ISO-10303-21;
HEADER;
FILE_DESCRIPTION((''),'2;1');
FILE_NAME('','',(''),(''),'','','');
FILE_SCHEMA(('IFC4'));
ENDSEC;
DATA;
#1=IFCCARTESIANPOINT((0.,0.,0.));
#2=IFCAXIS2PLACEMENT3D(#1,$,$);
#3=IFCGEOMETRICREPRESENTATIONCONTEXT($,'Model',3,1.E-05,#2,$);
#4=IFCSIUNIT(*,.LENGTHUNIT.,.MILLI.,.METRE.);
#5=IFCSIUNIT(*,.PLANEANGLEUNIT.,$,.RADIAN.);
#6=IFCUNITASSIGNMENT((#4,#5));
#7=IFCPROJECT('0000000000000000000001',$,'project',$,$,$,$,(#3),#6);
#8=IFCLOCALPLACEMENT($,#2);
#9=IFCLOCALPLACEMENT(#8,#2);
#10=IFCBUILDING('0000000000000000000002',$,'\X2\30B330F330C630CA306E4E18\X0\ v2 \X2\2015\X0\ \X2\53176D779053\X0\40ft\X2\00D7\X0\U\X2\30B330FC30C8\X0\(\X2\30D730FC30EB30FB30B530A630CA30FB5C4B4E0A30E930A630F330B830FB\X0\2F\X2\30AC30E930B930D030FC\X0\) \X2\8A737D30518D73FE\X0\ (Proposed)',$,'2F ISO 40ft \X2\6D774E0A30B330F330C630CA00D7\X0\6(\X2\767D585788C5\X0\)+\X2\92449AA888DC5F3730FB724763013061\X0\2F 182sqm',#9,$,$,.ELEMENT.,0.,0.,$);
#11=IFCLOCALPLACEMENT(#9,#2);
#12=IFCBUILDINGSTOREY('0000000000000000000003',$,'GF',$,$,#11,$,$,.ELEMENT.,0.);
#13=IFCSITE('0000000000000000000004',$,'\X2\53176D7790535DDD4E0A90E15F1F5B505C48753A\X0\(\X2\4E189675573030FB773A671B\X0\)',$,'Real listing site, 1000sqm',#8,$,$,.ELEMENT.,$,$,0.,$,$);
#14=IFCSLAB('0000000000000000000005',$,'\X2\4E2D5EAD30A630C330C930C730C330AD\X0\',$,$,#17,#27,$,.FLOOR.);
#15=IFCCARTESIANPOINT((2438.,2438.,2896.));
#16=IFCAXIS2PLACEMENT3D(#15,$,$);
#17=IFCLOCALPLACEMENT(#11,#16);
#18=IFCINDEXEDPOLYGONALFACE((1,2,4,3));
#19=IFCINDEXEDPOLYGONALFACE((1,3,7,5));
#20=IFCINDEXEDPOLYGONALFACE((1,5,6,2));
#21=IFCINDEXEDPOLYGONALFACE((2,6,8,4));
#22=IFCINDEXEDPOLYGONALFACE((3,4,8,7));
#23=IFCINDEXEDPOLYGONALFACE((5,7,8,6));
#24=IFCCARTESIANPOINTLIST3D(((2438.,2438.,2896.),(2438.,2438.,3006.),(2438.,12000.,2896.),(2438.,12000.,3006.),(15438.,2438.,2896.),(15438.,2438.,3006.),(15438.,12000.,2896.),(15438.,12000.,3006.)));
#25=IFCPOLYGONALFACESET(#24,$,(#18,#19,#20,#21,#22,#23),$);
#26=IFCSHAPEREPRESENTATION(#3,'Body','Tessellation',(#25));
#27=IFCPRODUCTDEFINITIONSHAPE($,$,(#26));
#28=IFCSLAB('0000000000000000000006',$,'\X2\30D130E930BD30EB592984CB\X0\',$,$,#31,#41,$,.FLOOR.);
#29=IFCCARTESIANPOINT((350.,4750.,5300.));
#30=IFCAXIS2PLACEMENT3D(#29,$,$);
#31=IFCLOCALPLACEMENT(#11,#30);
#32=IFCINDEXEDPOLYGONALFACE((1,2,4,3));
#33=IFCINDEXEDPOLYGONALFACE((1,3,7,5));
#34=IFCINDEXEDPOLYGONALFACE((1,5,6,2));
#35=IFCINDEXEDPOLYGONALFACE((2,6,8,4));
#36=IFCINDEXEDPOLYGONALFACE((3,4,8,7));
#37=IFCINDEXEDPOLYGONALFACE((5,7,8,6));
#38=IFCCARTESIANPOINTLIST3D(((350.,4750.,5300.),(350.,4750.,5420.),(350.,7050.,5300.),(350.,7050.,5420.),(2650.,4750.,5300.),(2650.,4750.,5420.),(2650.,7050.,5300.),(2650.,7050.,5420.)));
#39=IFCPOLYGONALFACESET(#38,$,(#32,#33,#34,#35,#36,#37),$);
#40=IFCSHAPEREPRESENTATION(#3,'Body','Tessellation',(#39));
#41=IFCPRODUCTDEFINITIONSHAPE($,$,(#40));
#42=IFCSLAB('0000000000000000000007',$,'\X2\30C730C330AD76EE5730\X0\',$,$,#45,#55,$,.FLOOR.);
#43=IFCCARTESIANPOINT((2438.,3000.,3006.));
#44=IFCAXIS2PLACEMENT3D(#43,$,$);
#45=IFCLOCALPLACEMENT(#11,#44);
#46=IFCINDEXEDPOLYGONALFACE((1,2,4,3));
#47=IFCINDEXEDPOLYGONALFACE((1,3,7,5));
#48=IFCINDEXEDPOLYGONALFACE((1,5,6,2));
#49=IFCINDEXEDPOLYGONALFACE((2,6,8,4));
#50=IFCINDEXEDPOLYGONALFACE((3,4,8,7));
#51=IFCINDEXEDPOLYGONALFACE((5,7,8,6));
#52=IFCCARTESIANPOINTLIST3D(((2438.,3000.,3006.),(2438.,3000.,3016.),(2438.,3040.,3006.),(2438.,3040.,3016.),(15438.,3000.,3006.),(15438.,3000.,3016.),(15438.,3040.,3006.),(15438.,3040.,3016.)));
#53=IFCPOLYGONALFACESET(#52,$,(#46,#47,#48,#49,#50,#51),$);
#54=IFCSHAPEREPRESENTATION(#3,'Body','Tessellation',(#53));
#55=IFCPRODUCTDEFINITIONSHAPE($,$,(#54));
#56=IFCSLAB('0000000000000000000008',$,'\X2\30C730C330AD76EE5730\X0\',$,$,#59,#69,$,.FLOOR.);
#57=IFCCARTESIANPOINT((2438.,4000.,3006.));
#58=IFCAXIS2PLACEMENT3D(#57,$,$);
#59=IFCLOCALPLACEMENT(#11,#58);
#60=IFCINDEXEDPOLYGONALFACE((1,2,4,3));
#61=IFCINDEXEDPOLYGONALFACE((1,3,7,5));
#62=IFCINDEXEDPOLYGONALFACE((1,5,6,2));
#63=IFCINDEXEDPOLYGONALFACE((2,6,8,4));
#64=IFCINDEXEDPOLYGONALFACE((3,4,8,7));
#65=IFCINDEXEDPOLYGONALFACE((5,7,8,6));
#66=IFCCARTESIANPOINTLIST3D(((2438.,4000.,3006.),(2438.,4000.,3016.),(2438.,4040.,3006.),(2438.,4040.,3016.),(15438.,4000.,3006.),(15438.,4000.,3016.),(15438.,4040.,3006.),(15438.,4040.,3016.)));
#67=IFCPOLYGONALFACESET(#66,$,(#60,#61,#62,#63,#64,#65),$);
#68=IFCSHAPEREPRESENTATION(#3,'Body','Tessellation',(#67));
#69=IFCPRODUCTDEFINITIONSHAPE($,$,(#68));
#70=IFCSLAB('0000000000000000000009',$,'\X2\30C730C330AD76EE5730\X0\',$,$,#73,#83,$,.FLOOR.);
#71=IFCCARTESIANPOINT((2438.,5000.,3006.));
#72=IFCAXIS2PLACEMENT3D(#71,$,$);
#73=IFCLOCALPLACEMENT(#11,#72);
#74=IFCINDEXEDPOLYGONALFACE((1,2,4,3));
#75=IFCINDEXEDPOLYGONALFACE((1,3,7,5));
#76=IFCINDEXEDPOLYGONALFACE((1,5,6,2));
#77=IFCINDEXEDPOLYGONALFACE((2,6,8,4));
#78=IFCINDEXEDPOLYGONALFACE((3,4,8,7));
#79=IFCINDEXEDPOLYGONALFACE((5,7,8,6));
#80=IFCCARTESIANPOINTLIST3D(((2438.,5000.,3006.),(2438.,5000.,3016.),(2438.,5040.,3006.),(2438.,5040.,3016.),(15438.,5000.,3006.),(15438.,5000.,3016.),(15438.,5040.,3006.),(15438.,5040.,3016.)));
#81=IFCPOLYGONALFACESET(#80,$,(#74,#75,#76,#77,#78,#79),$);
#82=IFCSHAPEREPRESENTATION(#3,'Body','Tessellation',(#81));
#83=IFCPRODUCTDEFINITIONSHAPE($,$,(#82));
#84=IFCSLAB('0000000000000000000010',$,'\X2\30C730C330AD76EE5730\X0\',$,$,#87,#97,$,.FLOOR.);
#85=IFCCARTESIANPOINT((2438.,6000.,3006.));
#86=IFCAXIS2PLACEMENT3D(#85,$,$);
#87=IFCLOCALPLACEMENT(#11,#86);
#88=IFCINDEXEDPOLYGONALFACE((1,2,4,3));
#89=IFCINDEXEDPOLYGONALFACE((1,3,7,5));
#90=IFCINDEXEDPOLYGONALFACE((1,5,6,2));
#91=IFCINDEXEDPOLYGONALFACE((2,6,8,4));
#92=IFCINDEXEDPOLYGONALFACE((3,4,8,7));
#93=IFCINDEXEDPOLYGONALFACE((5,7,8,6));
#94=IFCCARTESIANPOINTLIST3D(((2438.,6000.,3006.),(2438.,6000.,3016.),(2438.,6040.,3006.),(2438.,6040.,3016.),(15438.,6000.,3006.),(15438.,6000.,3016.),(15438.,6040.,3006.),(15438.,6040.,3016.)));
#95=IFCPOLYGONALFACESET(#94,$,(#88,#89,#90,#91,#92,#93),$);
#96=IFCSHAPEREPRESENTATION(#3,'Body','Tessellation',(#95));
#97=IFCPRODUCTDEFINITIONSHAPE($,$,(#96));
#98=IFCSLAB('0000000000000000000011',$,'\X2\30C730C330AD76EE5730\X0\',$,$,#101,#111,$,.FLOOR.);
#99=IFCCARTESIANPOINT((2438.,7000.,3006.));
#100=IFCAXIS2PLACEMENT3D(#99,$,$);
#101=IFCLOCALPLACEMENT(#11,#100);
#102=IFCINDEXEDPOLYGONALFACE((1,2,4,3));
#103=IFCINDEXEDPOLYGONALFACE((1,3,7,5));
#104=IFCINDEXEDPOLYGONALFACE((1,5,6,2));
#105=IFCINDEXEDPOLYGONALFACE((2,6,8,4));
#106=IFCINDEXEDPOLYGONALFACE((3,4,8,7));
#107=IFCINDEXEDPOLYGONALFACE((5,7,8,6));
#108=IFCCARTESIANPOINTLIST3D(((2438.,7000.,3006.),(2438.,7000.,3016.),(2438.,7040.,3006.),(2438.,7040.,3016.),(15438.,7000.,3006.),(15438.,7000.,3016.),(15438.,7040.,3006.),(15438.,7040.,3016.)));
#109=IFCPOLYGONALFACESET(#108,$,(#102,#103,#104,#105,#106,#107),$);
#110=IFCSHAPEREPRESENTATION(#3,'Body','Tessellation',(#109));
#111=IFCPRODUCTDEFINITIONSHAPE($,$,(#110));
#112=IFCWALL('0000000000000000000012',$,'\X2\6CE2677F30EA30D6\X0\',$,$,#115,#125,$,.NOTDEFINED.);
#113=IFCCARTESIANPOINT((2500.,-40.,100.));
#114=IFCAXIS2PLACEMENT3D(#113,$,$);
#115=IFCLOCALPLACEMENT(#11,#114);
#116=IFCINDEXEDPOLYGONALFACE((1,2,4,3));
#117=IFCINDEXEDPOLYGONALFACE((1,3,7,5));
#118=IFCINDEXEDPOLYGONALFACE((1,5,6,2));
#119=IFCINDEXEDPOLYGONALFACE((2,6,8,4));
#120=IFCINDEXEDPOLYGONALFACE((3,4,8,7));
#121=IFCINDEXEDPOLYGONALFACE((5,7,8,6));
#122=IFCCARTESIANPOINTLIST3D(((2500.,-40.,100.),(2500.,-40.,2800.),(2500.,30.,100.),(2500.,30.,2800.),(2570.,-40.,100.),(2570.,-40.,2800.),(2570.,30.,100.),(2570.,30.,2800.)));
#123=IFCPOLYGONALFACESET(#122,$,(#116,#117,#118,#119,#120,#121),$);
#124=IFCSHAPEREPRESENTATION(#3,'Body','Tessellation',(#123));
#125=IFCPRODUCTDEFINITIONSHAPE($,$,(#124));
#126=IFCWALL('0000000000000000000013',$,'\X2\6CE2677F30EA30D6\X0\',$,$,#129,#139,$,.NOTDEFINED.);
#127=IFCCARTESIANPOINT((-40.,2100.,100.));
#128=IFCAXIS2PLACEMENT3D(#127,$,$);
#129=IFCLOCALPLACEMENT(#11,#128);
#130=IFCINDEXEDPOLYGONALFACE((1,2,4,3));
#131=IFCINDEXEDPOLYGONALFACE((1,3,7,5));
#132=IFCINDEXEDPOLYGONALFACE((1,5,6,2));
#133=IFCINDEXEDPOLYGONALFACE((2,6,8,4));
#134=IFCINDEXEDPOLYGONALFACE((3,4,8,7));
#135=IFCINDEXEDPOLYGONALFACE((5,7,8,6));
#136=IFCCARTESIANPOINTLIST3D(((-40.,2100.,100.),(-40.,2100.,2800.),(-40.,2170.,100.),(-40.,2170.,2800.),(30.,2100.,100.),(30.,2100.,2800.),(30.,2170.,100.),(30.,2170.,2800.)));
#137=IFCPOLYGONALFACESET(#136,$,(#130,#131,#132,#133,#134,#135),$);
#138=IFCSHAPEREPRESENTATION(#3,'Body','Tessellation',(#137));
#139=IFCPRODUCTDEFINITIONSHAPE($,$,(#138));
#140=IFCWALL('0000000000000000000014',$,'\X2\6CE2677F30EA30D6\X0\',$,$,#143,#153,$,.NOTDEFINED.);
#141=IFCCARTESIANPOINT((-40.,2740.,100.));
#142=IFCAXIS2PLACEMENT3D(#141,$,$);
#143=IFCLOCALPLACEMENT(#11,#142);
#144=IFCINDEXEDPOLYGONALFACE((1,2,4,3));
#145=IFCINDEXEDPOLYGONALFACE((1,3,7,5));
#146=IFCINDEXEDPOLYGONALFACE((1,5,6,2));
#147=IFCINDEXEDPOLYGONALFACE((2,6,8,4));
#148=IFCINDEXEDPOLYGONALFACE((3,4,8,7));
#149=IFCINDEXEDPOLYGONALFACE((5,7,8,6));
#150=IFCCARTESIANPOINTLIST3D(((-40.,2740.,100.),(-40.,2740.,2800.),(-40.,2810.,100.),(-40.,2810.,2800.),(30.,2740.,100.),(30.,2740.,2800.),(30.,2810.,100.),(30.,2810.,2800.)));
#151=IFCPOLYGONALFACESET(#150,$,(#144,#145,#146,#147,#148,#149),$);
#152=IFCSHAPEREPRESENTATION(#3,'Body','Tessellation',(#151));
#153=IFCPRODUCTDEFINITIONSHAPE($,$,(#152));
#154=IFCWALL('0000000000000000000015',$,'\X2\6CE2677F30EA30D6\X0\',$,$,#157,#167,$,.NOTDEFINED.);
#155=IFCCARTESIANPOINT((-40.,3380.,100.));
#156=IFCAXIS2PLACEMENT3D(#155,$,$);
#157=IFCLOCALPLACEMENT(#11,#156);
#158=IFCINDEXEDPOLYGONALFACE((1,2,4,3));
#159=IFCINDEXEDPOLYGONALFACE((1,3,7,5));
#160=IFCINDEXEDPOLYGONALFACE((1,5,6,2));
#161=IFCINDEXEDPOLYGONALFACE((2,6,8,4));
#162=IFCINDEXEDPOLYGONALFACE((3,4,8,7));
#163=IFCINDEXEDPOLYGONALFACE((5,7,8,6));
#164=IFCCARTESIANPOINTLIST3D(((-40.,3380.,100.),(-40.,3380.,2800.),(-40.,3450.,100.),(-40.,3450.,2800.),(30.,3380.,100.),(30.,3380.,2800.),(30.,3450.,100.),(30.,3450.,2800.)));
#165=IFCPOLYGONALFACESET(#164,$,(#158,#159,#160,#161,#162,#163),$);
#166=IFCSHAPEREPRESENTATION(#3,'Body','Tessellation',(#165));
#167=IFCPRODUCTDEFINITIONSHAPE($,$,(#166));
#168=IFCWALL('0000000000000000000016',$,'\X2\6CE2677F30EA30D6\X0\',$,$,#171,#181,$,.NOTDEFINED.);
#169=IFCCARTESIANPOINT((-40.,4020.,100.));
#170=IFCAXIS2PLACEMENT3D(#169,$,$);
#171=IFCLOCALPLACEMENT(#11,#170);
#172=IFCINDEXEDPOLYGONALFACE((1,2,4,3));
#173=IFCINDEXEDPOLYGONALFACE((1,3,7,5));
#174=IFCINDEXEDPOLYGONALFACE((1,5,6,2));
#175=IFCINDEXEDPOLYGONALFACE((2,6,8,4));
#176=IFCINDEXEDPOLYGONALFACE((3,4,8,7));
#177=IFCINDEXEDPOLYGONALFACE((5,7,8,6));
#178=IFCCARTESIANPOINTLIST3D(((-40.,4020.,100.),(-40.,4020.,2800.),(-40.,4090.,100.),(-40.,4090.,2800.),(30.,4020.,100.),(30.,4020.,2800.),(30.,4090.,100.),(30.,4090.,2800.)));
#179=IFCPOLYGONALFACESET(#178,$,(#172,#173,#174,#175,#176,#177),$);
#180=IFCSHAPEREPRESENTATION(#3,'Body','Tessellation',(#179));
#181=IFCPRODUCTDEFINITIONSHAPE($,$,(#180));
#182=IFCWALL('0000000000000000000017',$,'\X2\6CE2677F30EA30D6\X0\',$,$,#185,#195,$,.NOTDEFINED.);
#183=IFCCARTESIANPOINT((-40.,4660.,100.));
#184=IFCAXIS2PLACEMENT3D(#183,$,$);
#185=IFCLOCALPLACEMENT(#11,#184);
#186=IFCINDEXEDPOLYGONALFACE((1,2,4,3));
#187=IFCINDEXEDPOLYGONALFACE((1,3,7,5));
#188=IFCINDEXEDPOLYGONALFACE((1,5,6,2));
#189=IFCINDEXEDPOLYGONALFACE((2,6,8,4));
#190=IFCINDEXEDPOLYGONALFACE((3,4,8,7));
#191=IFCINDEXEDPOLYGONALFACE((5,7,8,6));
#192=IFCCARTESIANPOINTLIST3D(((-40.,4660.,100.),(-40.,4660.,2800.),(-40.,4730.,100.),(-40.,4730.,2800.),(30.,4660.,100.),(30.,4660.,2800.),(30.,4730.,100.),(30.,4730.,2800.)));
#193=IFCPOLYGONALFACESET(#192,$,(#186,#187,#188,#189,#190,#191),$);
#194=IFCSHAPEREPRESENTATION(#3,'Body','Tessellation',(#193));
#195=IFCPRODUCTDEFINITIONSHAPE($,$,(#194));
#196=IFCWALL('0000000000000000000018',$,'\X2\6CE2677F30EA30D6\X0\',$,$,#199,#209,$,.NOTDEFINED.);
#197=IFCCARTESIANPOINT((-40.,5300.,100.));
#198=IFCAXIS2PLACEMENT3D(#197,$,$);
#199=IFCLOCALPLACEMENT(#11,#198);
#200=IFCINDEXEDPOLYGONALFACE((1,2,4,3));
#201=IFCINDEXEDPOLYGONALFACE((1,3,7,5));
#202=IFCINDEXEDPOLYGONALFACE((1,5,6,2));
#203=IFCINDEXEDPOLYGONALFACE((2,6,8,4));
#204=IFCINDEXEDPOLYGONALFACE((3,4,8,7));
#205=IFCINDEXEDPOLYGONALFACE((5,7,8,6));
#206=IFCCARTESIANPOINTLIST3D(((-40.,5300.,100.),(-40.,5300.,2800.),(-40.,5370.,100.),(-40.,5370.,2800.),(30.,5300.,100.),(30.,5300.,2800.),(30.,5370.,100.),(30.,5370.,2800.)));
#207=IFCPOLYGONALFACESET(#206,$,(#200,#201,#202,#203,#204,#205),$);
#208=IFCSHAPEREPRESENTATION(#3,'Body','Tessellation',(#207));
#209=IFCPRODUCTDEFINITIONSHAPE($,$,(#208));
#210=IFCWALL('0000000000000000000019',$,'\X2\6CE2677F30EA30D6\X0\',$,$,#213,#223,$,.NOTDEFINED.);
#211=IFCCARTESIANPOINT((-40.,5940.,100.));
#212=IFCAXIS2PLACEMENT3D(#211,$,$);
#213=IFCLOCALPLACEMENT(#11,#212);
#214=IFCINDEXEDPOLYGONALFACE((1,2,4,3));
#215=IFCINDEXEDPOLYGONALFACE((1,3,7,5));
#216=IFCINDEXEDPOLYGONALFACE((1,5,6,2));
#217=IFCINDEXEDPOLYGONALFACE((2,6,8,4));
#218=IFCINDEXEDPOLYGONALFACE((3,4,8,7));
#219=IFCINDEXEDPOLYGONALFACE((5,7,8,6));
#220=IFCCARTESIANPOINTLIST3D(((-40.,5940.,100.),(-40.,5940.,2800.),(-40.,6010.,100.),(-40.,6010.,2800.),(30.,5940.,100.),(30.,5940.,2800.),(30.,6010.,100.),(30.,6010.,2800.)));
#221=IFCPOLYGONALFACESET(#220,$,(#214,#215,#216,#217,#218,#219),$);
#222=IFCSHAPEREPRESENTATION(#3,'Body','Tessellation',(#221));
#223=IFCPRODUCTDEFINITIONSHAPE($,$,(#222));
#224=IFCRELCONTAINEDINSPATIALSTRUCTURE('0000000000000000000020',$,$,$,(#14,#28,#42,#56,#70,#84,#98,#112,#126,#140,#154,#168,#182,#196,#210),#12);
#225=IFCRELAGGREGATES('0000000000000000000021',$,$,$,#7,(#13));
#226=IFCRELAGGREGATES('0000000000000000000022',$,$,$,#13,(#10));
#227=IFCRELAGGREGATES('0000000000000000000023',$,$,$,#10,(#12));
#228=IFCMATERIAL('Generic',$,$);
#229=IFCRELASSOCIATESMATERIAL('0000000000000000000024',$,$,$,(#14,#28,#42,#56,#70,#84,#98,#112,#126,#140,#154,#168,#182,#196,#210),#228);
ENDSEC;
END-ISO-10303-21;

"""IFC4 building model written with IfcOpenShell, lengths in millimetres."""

from ifc_helpers import new_model, si_unit, frame, frame_2d, origin, place, context, project, spatial, rectangle, extrude, material, element, save


model = new_model("IFC4")

# Units and contexts
model_context = context("Model", 3, precision=1e-05, world=origin())
ifc_project = project(units=[si_unit("LENGTHUNIT", "METRE", prefix="MILLI"), si_unit("PLANEANGLEUNIT", "RADIAN")], contexts=[model_context])

# Site, building, storey
site_placement = place(None, origin())
site = spatial("IfcSite", under=ifc_project, at=site_placement, Name="北海道川上郡弟子屈町(丘陵地・眺望)", ObjectType="Real listing site, 1000sqm", CompositionType="ELEMENT", RefElevation=0.0)
building_placement = place(site_placement, origin())
building = spatial("IfcBuilding", under=site, at=building_placement, Name="コンテナの丘 v2 ― 北海道40ft×Uコート(プール・サウナ・屋上ラウンジ・2Fガラスバー) 詳細再現 (Proposed)", ObjectType="2F ISO 40ft 海上コンテナ×6(白塗装)+鉄骨補強・片持ち2F 182sqm", CompositionType="ELEMENT", ElevationOfRefHeight=0.0, ElevationOfTerrain=0.0)
storey_placement = place(building_placement, origin())
storey = spatial("IfcBuildingStorey", under=building, at=storey_placement, Name="GF", CompositionType="ELEMENT", Elevation=0.0)

# Slabs
ifc_material = material(Name="Generic")
slab_1_placement = place(storey_placement, frame((2438.0, 2438.0, 2896.0)))
element("IfcSlab", 1, at=slab_1_placement, inside=storey, material=ifc_material, Name="中庭ウッドデッキ", PredefinedType="FLOOR", context=model_context, shape_type="SweptSolid", body=[
    extrude(rectangle(XDim=13000.0, YDim=9562.0, at=frame_2d((6500.0, 4781.0))), frame((2438.0, 2438.0, 2896.0)), (0.0, 0.0, 1.0), 110.0),
])
slab_2_placement = place(storey_placement, frame((350.0, 4750.0, 5300.0)))
element("IfcSlab", 2, at=slab_2_placement, inside=storey, material=ifc_material, Name="パラソル天蓋", PredefinedType="FLOOR", context=model_context, shape_type="SweptSolid", body=[
    extrude(rectangle(XDim=2300.0, YDim=2300.0, at=frame_2d((1150.0, 1150.0))), frame((350.0, 4750.0, 5300.0)), (0.0, 0.0, 1.0), 120.0),
])
slab_3_placement = place(storey_placement, frame((2438.0, 3000.0, 3006.0)))
element("IfcSlab", 3, at=slab_3_placement, inside=storey, material=ifc_material, Name="デッキ目地", PredefinedType="FLOOR", context=model_context, shape_type="SweptSolid", body=[
    extrude(rectangle(XDim=13000.0, YDim=40.0, at=frame_2d((6500.0, 20.0))), frame((2438.0, 3000.0, 3006.0)), (0.0, 0.0, 1.0), 10.0),
])
slab_4_placement = place(storey_placement, frame((2438.0, 4000.0, 3006.0)))
element("IfcSlab", 4, at=slab_4_placement, inside=storey, material=ifc_material, Name="デッキ目地", PredefinedType="FLOOR", context=model_context, shape_type="SweptSolid", body=[
    extrude(rectangle(XDim=13000.0, YDim=40.0, at=frame_2d((6500.0, 20.0))), frame((2438.0, 4000.0, 3006.0)), (0.0, 0.0, 1.0), 10.0),
])
slab_5_placement = place(storey_placement, frame((2438.0, 5000.0, 3006.0)))
element("IfcSlab", 5, at=slab_5_placement, inside=storey, material=ifc_material, Name="デッキ目地", PredefinedType="FLOOR", context=model_context, shape_type="SweptSolid", body=[
    extrude(rectangle(XDim=13000.0, YDim=40.0, at=frame_2d((6500.0, 20.0))), frame((2438.0, 5000.0, 3006.0)), (0.0, 0.0, 1.0), 10.0),
])
slab_6_placement = place(storey_placement, frame((2438.0, 6000.0, 3006.0)))
element("IfcSlab", 6, at=slab_6_placement, inside=storey, material=ifc_material, Name="デッキ目地", PredefinedType="FLOOR", context=model_context, shape_type="SweptSolid", body=[
    extrude(rectangle(XDim=13000.0, YDim=40.0, at=frame_2d((6500.0, 20.0))), frame((2438.0, 6000.0, 3006.0)), (0.0, 0.0, 1.0), 10.0),
])
slab_7_placement = place(storey_placement, frame((2438.0, 7000.0, 3006.0)))
element("IfcSlab", 7, at=slab_7_placement, inside=storey, material=ifc_material, Name="デッキ目地", PredefinedType="FLOOR", context=model_context, shape_type="SweptSolid", body=[
    extrude(rectangle(XDim=13000.0, YDim=40.0, at=frame_2d((6500.0, 20.0))), frame((2438.0, 7000.0, 3006.0)), (0.0, 0.0, 1.0), 10.0),
])

# Walls
wall_1_placement = place(storey_placement, frame((2500.0, -40.0, 100.0)))
element("IfcWall", 8, at=wall_1_placement, inside=storey, material=ifc_material, Name="波板リブ", PredefinedType="NOTDEFINED", context=model_context, shape_type="SweptSolid", body=[
    extrude(rectangle(XDim=70.0, YDim=70.0, at=frame_2d((35.0, 35.0))), frame((2500.0, -40.0, 100.0)), (0.0, 0.0, 1.0), 2700.0),
])
wall_2_placement = place(storey_placement, frame((-40.0, 2100.0, 100.0)))
element("IfcWall", 9, at=wall_2_placement, inside=storey, material=ifc_material, Name="波板リブ", PredefinedType="NOTDEFINED", context=model_context, shape_type="SweptSolid", body=[
    extrude(rectangle(XDim=70.0, YDim=70.0, at=frame_2d((35.0, 35.0))), frame((-40.0, 2100.0, 100.0)), (0.0, 0.0, 1.0), 2700.0),
])
wall_3_placement = place(storey_placement, frame((-40.0, 2740.0, 100.0)))
element("IfcWall", 10, at=wall_3_placement, inside=storey, material=ifc_material, Name="波板リブ", PredefinedType="NOTDEFINED", context=model_context, shape_type="SweptSolid", body=[
    extrude(rectangle(XDim=70.0, YDim=70.0, at=frame_2d((35.0, 35.0))), frame((-40.0, 2740.0, 100.0)), (0.0, 0.0, 1.0), 2700.0),
])
wall_4_placement = place(storey_placement, frame((-40.0, 3380.0, 100.0)))
element("IfcWall", 11, at=wall_4_placement, inside=storey, material=ifc_material, Name="波板リブ", PredefinedType="NOTDEFINED", context=model_context, shape_type="SweptSolid", body=[
    extrude(rectangle(XDim=70.0, YDim=70.0, at=frame_2d((35.0, 35.0))), frame((-40.0, 3380.0, 100.0)), (0.0, 0.0, 1.0), 2700.0),
])
wall_5_placement = place(storey_placement, frame((-40.0, 4020.0, 100.0)))
element("IfcWall", 12, at=wall_5_placement, inside=storey, material=ifc_material, Name="波板リブ", PredefinedType="NOTDEFINED", context=model_context, shape_type="SweptSolid", body=[
    extrude(rectangle(XDim=70.0, YDim=70.0, at=frame_2d((35.0, 35.0))), frame((-40.0, 4020.0, 100.0)), (0.0, 0.0, 1.0), 2700.0),
])
wall_6_placement = place(storey_placement, frame((-40.0, 4660.0, 100.0)))
element("IfcWall", 13, at=wall_6_placement, inside=storey, material=ifc_material, Name="波板リブ", PredefinedType="NOTDEFINED", context=model_context, shape_type="SweptSolid", body=[
    extrude(rectangle(XDim=70.0, YDim=70.0, at=frame_2d((35.0, 35.0))), frame((-40.0, 4660.0, 100.0)), (0.0, 0.0, 1.0), 2700.0),
])
wall_7_placement = place(storey_placement, frame((-40.0, 5300.0, 100.0)))
element("IfcWall", 14, at=wall_7_placement, inside=storey, material=ifc_material, Name="波板リブ", PredefinedType="NOTDEFINED", context=model_context, shape_type="SweptSolid", body=[
    extrude(rectangle(XDim=70.0, YDim=70.0, at=frame_2d((35.0, 35.0))), frame((-40.0, 5300.0, 100.0)), (0.0, 0.0, 1.0), 2700.0),
])
wall_8_placement = place(storey_placement, frame((-40.0, 5940.0, 100.0)))
element("IfcWall", 15, at=wall_8_placement, inside=storey, material=ifc_material, Name="波板リブ", PredefinedType="NOTDEFINED", context=model_context, shape_type="SweptSolid", body=[
    extrude(rectangle(XDim=70.0, YDim=70.0, at=frame_2d((35.0, 35.0))), frame((-40.0, 5940.0, 100.0)), (0.0, 0.0, 1.0), 2700.0),
])

save(model, "model.ifc")
